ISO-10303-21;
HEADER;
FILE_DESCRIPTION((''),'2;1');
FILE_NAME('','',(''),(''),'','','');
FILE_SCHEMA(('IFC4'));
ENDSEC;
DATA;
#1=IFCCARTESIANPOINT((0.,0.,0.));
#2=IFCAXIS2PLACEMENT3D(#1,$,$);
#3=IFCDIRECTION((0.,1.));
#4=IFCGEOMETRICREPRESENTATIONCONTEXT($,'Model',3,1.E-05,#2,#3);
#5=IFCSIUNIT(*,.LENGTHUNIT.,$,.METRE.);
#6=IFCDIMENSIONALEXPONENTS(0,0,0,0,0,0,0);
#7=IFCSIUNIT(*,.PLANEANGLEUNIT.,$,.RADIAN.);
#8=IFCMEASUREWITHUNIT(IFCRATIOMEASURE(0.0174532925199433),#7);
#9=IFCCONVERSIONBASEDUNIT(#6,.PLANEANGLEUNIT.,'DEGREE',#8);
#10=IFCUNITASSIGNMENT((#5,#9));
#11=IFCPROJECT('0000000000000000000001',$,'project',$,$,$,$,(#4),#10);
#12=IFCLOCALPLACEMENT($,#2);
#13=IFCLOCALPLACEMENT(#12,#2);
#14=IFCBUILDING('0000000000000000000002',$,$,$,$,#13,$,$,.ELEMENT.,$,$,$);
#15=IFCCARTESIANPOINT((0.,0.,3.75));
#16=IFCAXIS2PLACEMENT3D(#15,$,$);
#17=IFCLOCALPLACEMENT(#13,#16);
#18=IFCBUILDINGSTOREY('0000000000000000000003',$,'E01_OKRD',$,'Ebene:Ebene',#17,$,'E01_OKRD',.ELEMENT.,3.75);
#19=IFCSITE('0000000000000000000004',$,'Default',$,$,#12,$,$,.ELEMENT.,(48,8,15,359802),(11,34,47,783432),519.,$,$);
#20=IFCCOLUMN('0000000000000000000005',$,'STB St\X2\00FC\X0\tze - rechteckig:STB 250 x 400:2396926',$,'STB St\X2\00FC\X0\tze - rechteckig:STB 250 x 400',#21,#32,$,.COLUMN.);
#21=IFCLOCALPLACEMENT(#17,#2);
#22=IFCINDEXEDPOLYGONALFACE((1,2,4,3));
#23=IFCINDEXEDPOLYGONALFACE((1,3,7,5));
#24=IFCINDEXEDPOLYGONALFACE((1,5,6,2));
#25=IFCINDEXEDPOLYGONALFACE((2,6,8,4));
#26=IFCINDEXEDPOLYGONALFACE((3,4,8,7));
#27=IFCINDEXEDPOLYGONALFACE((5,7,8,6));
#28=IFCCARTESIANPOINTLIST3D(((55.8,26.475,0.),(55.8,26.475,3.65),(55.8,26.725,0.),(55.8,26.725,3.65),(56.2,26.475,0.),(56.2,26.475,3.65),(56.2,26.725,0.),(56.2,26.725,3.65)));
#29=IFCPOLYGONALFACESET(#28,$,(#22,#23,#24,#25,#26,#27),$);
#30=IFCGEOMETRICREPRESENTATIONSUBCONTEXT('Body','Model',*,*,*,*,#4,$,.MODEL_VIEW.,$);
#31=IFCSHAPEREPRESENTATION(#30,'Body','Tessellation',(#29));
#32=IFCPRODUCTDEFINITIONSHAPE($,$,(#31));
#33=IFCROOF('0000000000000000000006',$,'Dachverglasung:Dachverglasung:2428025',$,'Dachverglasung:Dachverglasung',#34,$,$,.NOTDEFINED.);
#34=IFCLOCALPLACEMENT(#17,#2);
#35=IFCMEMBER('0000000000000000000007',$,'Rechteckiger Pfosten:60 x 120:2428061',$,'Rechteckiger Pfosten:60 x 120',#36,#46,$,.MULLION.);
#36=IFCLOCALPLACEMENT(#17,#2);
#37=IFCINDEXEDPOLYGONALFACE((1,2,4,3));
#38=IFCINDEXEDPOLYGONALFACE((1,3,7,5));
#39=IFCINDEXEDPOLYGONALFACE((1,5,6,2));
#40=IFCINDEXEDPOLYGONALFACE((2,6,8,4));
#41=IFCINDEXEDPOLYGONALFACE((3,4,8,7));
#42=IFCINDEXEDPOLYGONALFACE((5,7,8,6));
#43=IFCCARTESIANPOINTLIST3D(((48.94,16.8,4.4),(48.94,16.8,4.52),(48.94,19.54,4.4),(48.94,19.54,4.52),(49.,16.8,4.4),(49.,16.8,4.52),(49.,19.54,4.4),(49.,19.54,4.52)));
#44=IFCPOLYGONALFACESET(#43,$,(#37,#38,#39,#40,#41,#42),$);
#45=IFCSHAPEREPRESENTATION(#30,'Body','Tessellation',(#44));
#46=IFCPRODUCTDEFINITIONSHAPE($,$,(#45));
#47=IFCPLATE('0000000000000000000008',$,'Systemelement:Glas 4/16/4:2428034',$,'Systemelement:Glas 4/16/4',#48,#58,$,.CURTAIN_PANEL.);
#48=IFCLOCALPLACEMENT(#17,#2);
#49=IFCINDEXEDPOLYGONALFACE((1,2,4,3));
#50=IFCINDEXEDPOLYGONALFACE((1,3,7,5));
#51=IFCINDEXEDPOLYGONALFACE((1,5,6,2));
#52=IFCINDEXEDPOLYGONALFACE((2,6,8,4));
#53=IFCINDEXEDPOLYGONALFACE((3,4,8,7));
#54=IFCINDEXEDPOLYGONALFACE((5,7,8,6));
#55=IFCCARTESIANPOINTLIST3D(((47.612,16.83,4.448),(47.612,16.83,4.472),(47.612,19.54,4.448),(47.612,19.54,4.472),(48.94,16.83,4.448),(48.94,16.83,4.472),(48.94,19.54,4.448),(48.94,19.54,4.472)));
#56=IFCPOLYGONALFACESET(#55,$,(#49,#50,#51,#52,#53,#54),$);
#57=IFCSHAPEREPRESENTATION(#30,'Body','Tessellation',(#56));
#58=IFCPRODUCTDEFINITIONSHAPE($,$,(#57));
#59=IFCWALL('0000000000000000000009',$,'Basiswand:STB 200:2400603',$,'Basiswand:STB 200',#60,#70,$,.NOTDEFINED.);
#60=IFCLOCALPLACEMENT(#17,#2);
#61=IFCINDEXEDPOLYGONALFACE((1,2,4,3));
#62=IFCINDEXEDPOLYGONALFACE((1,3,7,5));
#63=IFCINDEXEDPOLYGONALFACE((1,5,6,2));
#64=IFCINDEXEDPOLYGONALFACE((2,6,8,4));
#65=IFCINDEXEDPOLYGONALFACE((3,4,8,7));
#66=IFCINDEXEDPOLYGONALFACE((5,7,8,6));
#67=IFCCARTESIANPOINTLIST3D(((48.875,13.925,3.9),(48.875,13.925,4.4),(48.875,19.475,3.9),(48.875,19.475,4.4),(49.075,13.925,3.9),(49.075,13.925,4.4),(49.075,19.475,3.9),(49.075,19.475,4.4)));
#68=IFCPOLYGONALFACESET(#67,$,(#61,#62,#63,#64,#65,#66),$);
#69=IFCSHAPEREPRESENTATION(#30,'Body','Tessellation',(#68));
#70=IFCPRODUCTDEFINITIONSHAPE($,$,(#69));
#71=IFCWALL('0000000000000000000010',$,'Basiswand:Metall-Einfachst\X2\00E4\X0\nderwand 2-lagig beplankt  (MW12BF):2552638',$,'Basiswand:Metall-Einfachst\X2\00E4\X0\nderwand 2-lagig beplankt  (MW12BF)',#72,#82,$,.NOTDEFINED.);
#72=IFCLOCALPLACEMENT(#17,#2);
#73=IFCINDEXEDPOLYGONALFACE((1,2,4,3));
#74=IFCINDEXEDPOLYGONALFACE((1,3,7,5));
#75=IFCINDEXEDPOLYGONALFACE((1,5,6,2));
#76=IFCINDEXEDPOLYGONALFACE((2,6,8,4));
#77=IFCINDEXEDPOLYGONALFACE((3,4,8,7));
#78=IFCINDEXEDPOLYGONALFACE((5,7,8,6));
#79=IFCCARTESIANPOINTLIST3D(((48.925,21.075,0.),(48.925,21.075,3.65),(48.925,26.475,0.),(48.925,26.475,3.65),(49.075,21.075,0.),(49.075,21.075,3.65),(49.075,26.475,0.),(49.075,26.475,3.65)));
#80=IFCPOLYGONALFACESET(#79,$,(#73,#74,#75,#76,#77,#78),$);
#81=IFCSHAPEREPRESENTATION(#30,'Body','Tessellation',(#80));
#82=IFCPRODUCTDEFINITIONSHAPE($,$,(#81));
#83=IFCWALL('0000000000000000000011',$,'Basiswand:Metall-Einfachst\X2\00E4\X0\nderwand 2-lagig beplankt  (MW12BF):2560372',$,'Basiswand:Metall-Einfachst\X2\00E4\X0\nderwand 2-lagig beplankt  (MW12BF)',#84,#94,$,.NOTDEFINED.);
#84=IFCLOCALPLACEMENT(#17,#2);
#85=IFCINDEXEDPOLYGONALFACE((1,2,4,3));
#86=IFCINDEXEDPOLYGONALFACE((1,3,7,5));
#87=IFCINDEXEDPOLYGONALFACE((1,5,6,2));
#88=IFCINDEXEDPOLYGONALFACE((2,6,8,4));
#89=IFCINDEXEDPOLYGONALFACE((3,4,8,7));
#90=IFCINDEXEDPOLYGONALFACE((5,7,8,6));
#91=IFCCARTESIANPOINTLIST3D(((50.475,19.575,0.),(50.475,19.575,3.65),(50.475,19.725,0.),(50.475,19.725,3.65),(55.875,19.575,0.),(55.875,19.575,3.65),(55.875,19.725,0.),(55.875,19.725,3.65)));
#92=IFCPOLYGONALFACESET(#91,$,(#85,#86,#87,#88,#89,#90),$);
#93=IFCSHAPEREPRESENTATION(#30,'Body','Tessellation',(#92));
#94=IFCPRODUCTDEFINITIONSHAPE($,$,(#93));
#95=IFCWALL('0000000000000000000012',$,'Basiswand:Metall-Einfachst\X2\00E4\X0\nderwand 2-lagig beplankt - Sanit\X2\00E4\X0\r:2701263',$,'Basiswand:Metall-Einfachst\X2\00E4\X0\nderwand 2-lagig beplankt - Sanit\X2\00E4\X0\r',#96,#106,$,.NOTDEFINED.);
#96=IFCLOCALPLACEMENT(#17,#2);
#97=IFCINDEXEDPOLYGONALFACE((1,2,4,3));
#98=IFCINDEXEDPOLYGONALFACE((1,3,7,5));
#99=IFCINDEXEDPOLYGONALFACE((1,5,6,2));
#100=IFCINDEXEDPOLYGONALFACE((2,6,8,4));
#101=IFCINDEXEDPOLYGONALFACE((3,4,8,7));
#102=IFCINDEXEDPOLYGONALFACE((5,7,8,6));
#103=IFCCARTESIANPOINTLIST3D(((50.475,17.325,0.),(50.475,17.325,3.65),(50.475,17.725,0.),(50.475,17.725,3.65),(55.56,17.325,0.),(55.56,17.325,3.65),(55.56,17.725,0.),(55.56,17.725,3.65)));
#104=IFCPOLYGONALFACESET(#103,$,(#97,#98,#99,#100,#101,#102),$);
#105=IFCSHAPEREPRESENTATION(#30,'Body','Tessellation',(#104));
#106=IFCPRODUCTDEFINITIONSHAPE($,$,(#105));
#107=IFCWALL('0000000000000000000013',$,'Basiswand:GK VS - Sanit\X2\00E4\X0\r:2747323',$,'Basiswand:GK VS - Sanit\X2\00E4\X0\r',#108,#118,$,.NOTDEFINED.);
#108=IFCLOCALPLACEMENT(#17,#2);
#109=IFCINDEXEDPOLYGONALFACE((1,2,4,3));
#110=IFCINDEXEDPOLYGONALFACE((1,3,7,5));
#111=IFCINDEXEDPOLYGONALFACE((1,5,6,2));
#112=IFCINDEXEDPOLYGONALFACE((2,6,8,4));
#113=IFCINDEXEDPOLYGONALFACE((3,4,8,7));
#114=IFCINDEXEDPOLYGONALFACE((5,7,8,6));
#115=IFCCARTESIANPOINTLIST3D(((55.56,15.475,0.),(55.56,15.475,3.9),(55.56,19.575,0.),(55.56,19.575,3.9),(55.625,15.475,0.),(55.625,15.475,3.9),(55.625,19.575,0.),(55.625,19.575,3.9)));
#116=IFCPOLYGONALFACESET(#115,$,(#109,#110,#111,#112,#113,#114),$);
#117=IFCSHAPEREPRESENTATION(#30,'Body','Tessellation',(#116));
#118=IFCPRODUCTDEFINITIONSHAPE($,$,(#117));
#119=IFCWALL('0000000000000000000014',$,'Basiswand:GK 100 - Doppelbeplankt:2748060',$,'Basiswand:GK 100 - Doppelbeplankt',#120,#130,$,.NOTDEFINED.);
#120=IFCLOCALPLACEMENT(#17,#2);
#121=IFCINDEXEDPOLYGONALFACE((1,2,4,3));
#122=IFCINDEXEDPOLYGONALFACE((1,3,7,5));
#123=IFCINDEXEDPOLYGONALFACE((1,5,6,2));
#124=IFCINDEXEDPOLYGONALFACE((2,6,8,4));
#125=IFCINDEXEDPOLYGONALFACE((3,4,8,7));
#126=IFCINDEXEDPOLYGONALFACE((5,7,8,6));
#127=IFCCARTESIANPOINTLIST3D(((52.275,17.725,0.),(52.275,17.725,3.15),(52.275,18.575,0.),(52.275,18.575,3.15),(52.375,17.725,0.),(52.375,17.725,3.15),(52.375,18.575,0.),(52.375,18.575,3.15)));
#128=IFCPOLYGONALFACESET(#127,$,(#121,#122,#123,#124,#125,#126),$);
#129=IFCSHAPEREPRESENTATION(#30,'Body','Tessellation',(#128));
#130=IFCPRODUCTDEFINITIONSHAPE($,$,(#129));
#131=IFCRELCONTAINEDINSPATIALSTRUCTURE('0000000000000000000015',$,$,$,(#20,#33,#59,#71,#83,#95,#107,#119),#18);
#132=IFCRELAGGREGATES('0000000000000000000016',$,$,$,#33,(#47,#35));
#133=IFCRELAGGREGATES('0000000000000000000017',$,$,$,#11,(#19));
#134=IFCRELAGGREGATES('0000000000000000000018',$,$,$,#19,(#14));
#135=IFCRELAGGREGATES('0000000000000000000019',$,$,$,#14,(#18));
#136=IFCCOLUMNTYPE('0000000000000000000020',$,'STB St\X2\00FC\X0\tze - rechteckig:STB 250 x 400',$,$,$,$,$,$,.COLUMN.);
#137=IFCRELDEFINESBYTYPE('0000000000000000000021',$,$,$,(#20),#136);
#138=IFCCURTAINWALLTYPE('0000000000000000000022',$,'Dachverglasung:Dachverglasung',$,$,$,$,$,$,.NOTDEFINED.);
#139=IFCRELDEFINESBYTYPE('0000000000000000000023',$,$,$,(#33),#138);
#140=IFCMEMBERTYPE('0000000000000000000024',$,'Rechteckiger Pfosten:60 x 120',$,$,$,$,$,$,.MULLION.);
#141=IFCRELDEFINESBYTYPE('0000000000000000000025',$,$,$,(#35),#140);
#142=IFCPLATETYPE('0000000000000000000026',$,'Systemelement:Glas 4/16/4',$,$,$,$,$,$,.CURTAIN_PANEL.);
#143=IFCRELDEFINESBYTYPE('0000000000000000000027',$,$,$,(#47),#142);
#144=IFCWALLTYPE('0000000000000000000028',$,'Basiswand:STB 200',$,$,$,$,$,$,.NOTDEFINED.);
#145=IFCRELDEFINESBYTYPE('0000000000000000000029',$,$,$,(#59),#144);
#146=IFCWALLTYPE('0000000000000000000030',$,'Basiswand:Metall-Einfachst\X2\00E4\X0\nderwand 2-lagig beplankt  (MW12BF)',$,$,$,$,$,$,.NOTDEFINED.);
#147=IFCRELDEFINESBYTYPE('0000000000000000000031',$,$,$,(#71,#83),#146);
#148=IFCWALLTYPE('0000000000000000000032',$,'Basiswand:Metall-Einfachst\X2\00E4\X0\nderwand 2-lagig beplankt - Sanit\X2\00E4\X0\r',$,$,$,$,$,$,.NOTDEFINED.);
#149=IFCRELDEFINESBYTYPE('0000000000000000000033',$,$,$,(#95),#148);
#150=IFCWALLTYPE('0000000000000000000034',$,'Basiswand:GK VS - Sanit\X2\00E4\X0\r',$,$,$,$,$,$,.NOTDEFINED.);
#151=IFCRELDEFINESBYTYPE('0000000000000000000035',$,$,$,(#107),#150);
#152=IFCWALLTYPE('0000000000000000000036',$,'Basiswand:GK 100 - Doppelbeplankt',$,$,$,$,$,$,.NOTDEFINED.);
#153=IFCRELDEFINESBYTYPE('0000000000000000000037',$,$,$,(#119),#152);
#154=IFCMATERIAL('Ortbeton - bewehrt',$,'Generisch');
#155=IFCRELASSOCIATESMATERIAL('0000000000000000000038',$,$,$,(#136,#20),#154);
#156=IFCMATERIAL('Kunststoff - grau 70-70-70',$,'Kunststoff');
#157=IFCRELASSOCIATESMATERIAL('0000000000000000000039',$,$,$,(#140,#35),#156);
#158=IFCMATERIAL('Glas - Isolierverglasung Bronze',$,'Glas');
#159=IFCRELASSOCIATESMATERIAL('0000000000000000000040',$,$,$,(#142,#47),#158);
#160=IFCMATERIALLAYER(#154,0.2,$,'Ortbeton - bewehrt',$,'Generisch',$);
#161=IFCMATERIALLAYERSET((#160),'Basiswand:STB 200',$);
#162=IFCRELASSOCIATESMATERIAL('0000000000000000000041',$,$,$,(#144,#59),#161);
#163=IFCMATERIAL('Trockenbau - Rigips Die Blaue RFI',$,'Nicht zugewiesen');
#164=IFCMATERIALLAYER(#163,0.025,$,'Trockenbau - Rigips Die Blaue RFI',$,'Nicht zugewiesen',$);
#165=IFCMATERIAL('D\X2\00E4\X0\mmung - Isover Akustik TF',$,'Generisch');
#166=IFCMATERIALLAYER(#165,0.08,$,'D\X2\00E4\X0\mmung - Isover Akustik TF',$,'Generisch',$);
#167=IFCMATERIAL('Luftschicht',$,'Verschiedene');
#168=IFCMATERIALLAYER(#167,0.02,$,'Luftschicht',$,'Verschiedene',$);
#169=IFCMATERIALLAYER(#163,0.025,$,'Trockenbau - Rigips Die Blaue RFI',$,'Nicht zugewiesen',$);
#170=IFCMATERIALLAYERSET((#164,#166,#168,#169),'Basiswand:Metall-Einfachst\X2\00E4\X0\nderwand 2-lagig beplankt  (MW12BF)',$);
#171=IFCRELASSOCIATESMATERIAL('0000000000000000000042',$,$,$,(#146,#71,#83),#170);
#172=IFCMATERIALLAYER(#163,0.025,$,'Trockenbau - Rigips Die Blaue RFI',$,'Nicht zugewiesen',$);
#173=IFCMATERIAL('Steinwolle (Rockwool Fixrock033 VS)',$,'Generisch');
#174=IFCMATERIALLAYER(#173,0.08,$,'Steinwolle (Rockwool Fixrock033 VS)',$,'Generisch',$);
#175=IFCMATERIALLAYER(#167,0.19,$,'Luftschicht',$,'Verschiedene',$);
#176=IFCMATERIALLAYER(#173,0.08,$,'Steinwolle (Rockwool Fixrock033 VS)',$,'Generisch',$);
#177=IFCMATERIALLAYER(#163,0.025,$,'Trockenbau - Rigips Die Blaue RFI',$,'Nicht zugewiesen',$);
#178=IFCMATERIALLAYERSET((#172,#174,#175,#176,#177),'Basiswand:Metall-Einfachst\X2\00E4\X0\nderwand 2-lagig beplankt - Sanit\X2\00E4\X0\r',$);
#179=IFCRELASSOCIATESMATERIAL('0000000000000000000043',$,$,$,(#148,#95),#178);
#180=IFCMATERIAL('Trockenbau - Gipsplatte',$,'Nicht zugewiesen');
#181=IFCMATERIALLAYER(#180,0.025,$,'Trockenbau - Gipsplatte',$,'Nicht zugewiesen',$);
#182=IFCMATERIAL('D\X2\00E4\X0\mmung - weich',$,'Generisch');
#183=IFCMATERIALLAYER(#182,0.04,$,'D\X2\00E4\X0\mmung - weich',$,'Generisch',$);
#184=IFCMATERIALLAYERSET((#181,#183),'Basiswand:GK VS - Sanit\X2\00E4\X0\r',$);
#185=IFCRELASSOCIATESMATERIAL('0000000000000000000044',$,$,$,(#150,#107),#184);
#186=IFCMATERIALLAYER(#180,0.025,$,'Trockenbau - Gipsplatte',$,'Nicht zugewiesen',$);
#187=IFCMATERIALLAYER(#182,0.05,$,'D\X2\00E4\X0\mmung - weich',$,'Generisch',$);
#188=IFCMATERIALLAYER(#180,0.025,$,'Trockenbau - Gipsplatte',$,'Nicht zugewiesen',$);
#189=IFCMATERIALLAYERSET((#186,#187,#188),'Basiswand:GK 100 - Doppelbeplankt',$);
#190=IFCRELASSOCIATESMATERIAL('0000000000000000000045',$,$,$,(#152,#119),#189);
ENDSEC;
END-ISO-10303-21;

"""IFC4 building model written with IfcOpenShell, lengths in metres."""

from ifc_helpers import new_model, entity, si_unit, converted_unit, direction, frame, frame_2d, origin, origin_2d_with_axis, place, context, subcontext, project, spatial, rectangle, extrude, shape, source, transform, mapped, material, layer, layer_set, layer_usage, material_profile, profile_set, profile_usage, type_object, type_shapes, element, aggregate, save


model = new_model("IFC4")

# Units and contexts
model_context = context("Model", 3, precision=1e-05, world=origin(), true_north=direction((0.0, 1.0)))
body_context = subcontext(model_context, "Body", "Model", "MODEL_VIEW")
footprint_context = subcontext(model_context, "FootPrint", "Model", "MODEL_VIEW")
ifc_project = project(units=[si_unit("LENGTHUNIT", "METRE"), converted_unit("PLANEANGLEUNIT", "DEGREE", entity("IfcRatioMeasure", 0.0174532925199433), si_unit("PLANEANGLEUNIT", "RADIAN"), dimensions=[0, 0, 0, 0, 0, 0, 0])], contexts=[model_context])

# Site, building, storey
site_placement = place(None, frame((0.0, 0.0, 0.0)))
site = spatial("IfcSite", under=ifc_project, at=site_placement, Name="Default", CompositionType="ELEMENT", RefLatitude=(48, 8, 15, 359802), RefLongitude=(11, 34, 47, 783432), RefElevation=519.0)
building_placement = place(site_placement, origin())
building = spatial("IfcBuilding", under=site, at=building_placement, CompositionType="ELEMENT")
storey_placement = place(building_placement, frame((0.0, 0.0, 3.75)))
storey = spatial("IfcBuildingStorey", under=building, at=storey_placement, Name="E01_OKRD", ObjectType="Ebene:Ebene", LongName="E01_OKRD", CompositionType="ELEMENT", Elevation=3.75)

# Column
ifc_material_1 = material(Name="Ortbeton - bewehrt", Category="Generisch")
ifc_material_profile_1 = material_profile(ifc_material_1, rectangle(XDim=0.4, YDim=0.25, at=frame_2d((0.0, 0.0), x_axis=(1.0, 0.0))), Name="STB 250 x 400")
ifc_profile_set_1 = profile_set([ifc_material_profile_1], Name="STB 250 x 400")
ifc_profile_usage_1 = profile_usage(ifc_profile_set_1)
column_type = type_object("IfcColumnType", Name="STB Stütze - rechteckig:STB 250 x 400", PredefinedType="COLUMN", material=ifc_profile_set_1)
shared_shape_1 = source(origin(), body_context, "Body", "SweptSolid", [
    extrude(rectangle(XDim=0.4, YDim=0.25, at=frame_2d((0.0, 0.0), x_axis=(1.0, 0.0))), frame((0.2, 0.125, 0.0), z_axis=(0.0, 0.0, 1.0), x_axis=(-1.0, 0.0, 0.0)), (0.0, 0.0, 1.0), 3.65),
])
type_shapes(column_type, [shared_shape_1])
column_placement = place(storey_placement, frame((55.8, 26.475, 0.0)))
element("IfcColumn", 1, at=column_placement, inside=storey, type_object=column_type, material=ifc_profile_usage_1, Name="STB Stütze - rechteckig:STB 250 x 400:2396926", ObjectType="STB Stütze - rechteckig:STB 250 x 400", PredefinedType="COLUMN", context=body_context, shape_type="MappedRepresentation", body=[
    mapped(shared_shape_1, transform((0.0, 0.0, 0.0), scale=1.0)),
])

# Roof, member, plate
curtain_wall_type = type_object("IfcCurtainWallType", Name="Dachverglasung:Dachverglasung", PredefinedType="NOTDEFINED")
roof_placement = place(storey_placement, frame((0.0, 0.0, -3.75)))
roof = element("IfcRoof", 2, at=roof_placement, inside=storey, type_object=curtain_wall_type, Name="Dachverglasung:Dachverglasung:2428025", ObjectType="Dachverglasung:Dachverglasung", PredefinedType="NOTDEFINED")
ifc_material_2 = material(Name="Kunststoff - grau 70-70-70", Category="Kunststoff")
ifc_material_profile_2 = material_profile(ifc_material_2, rectangle(XDim=0.06, YDim=0.12, at=frame_2d((0.0, 0.0), x_axis=(1.0, 0.0))), Name="60 x 120")
ifc_profile_set_2 = profile_set([ifc_material_profile_2], Name="60 x 120")
ifc_profile_usage_2 = profile_usage(ifc_profile_set_2)
member_type = type_object("IfcMemberType", Name="Rechteckiger Pfosten:60 x 120", PredefinedType="MULLION", material=ifc_profile_set_2)
shared_shape_2 = source(origin(), body_context, "Body", "SweptSolid", [
    extrude(rectangle(XDim=0.06, YDim=0.12, at=origin_2d_with_axis()), frame((-0.03, 0.0, -2.74), z_axis=(0.0, 0.0, 1.0), x_axis=(-1.0, 0.0, 0.0)), (0.0, 0.0, 1.0), 2.74),
])
type_shapes(member_type, [shared_shape_2])
member_placement = place(storey_placement, frame((49.0, 19.54, 4.46), z_axis=(0.0, 1.0, 0.0), x_axis=(1.0, 0.0, 0.0)))
member = element("IfcMember", 3, at=member_placement, type_object=member_type, material=ifc_profile_usage_2, Name="Rechteckiger Pfosten:60 x 120:2428061", ObjectType="Rechteckiger Pfosten:60 x 120", PredefinedType="MULLION", context=body_context, shape_type="MappedRepresentation", body=[
    mapped(shared_shape_2, transform((0.0, 0.0, 0.0), scale=1.0)),
])
ifc_material_3 = material(Name="Glas - Isolierverglasung Bronze", Category="Glas")
plate_type = type_object("IfcPlateType", Name="Systemelement:Glas 4/16/4", PredefinedType="CURTAIN_PANEL", material=ifc_material_3)
shared_shape_3 = source(origin(), body_context, "Body", "SweptSolid", [
    extrude(rectangle(XDim=0.024, YDim=2.71, at=origin_2d_with_axis()), frame((0.0, 0.0, 0.0), z_axis=(0.0, 0.0, 1.0), x_axis=(0.0, 1.0, 0.0)), (0.0, 0.0, 1.0), 1.328),
])
cartesian_point = entity("IfcCartesianPoint", [1.355, -0.012])
shared_shape_4 = source(origin(), footprint_context, "FootPrint", "Curve2D", [
    entity("IfcPolyline", [cartesian_point, entity("IfcCartesianPoint", [1.355, 0.012]), entity("IfcCartesianPoint", [-1.355, 0.012]), entity("IfcCartesianPoint", [-1.355, -0.012]), cartesian_point]),
])
type_shapes(plate_type, [shared_shape_3, shared_shape_4])
plate_placement = place(roof_placement, frame((48.94, 18.185, 8.21), z_axis=(-1.0, 0.0, 0.0), x_axis=(0.0, 1.0, 0.0)))
plate = element("IfcPlate", 4, at=plate_placement, type_object=plate_type, material=ifc_material_3, Name="Systemelement:Glas 4/16/4:2428034", ObjectType="Systemelement:Glas 4/16/4", PredefinedType="CURTAIN_PANEL", shapes=[
    shape(body_context, "Body", "MappedRepresentation", [mapped(shared_shape_3, transform((0.0, 0.0, 0.0), scale=1.0))]),
    shape(body_context, "Body", "MappedRepresentation", [mapped(shared_shape_4, transform((0.0, 0.0, 0.0), scale=1.0))]),
])
aggregate(roof, [plate, member])

# Walls
ifc_layer_1 = layer(ifc_material_1, 0.2, Name="Ortbeton - bewehrt", Category="Generisch")
ifc_layer_set_1 = layer_set([ifc_layer_1], Name="Basiswand:STB 200")
ifc_layer_usage_1 = layer_usage(ifc_layer_set_1, "AXIS2", "NEGATIVE", 0.1)
wall_type_1 = type_object("IfcWallType", Name="Basiswand:STB 200", PredefinedType="NOTDEFINED", material=ifc_layer_set_1)
wall_1_placement = place(storey_placement, frame((48.975, 19.475, 3.9), z_axis=(0.0, 0.0, 1.0), x_axis=(0.0, -1.0, 0.0)))
element("IfcWall", 5, at=wall_1_placement, inside=storey, type_object=wall_type_1, material=ifc_layer_usage_1, Name="Basiswand:STB 200:2400603", ObjectType="Basiswand:STB 200", PredefinedType="NOTDEFINED", context=body_context, shape_type="SweptSolid", body=[
    extrude(rectangle(XDim=5.55, YDim=0.2, at=frame_2d((2.775, 0.0), x_axis=(-1.0, 0.0))), origin(), (0.0, 0.0, 1.0), 0.5),
])
ifc_material_4 = material(Name="Trockenbau - Rigips Die Blaue RFI", Category="Nicht zugewiesen")
ifc_layer_2 = layer(ifc_material_4, 0.025, Name="Trockenbau - Rigips Die Blaue RFI", Category="Nicht zugewiesen")
ifc_material_5 = material(Name="Dämmung - Isover Akustik TF", Category="Generisch")
ifc_layer_3 = layer(ifc_material_5, 0.08, Name="Dämmung - Isover Akustik TF", Category="Generisch")
ifc_material_6 = material(Name="Luftschicht", Category="Verschiedene")
ifc_layer_4 = layer(ifc_material_6, 0.02, Name="Luftschicht", Category="Verschiedene")
ifc_layer_5 = layer(ifc_material_4, 0.025, Name="Trockenbau - Rigips Die Blaue RFI", Category="Nicht zugewiesen")
ifc_layer_set_2 = layer_set([ifc_layer_2, ifc_layer_3, ifc_layer_4, ifc_layer_5], Name="Basiswand:Metall-Einfachständerwand 2-lagig beplankt  (MW12BF)")
ifc_layer_usage_2 = layer_usage(ifc_layer_set_2, "AXIS2", "NEGATIVE", 0.075)
wall_type_2 = type_object("IfcWallType", Name="Basiswand:Metall-Einfachständerwand 2-lagig beplankt  (MW12BF)", PredefinedType="NOTDEFINED", material=ifc_layer_set_2)
wall_2_placement = place(storey_placement, frame((49.0, 21.075, 0.0), z_axis=(0.0, 0.0, 1.0), x_axis=(0.0, 1.0, 0.0)))
element("IfcWall", 6, at=wall_2_placement, inside=storey, type_object=wall_type_2, material=ifc_layer_usage_2, Name="Basiswand:Metall-Einfachständerwand 2-lagig beplankt  (MW12BF):2552638", ObjectType="Basiswand:Metall-Einfachständerwand 2-lagig beplankt  (MW12BF)", PredefinedType="NOTDEFINED", context=body_context, shape_type="SweptSolid", body=[
    extrude(rectangle(XDim=5.4, YDim=0.15, at=frame_2d((2.7, 0.0), x_axis=(-1.0, 0.0))), origin(), (0.0, 0.0, 1.0), 3.65),
])
ifc_layer_usage_3 = layer_usage(ifc_layer_set_2, "AXIS2", "POSITIVE", -0.075)
wall_3_placement = place(storey_placement, frame((55.875, 19.65, 0.0), z_axis=(0.0, 0.0, 1.0), x_axis=(-1.0, 0.0, 0.0)))
element("IfcWall", 7, at=wall_3_placement, inside=storey, type_object=wall_type_2, material=ifc_layer_usage_3, Name="Basiswand:Metall-Einfachständerwand 2-lagig beplankt  (MW12BF):2560372", ObjectType="Basiswand:Metall-Einfachständerwand 2-lagig beplankt  (MW12BF)", PredefinedType="NOTDEFINED", context=body_context, shape_type="SweptSolid", body=[
    extrude(rectangle(XDim=5.4, YDim=0.15, at=frame_2d((2.7, 0.0), x_axis=(-1.0, 0.0))), origin(), (0.0, 0.0, 1.0), 3.65),
])
ifc_layer_6 = layer(ifc_material_4, 0.025, Name="Trockenbau - Rigips Die Blaue RFI", Category="Nicht zugewiesen")
ifc_material_7 = material(Name="Steinwolle (Rockwool Fixrock033 VS)", Category="Generisch")
ifc_layer_7 = layer(ifc_material_7, 0.08, Name="Steinwolle (Rockwool Fixrock033 VS)", Category="Generisch")
ifc_layer_8 = layer(ifc_material_6, 0.19, Name="Luftschicht", Category="Verschiedene")
ifc_layer_9 = layer(ifc_material_7, 0.08, Name="Steinwolle (Rockwool Fixrock033 VS)", Category="Generisch")
ifc_layer_10 = layer(ifc_material_4, 0.025, Name="Trockenbau - Rigips Die Blaue RFI", Category="Nicht zugewiesen")
ifc_layer_set_3 = layer_set([ifc_layer_6, ifc_layer_7, ifc_layer_8, ifc_layer_9, ifc_layer_10], Name="Basiswand:Metall-Einfachständerwand 2-lagig beplankt - Sanitär")
ifc_layer_usage_4 = layer_usage(ifc_layer_set_3, "AXIS2", "NEGATIVE", 0.2)
wall_type_3 = type_object("IfcWallType", Name="Basiswand:Metall-Einfachständerwand 2-lagig beplankt - Sanitär", PredefinedType="NOTDEFINED", material=ifc_layer_set_3)
wall_4_placement = place(storey_placement, frame((55.56, 17.525, 0.0), z_axis=(0.0, 0.0, 1.0), x_axis=(-1.0, 0.0, 0.0)))
element("IfcWall", 8, at=wall_4_placement, inside=storey, type_object=wall_type_3, material=ifc_layer_usage_4, Name="Basiswand:Metall-Einfachständerwand 2-lagig beplankt - Sanitär:2701263", ObjectType="Basiswand:Metall-Einfachständerwand 2-lagig beplankt - Sanitär", PredefinedType="NOTDEFINED", context=body_context, shape_type="SweptSolid", body=[
    extrude(rectangle(XDim=5.085, YDim=0.4, at=frame_2d((2.5425, 0.0), x_axis=(-1.0, 0.0))), origin(), (0.0, 0.0, 1.0), 3.65),
])
ifc_material_8 = material(Name="Trockenbau - Gipsplatte", Category="Nicht zugewiesen")
ifc_layer_11 = layer(ifc_material_8, 0.025, Name="Trockenbau - Gipsplatte", Category="Nicht zugewiesen")
ifc_material_9 = material(Name="Dämmung - weich", Category="Generisch")
ifc_layer_12 = layer(ifc_material_9, 0.04, Name="Dämmung - weich", Category="Generisch")
ifc_layer_set_4 = layer_set([ifc_layer_11, ifc_layer_12], Name="Basiswand:GK VS - Sanitär")
ifc_layer_usage_5 = layer_usage(ifc_layer_set_4, "AXIS2", "POSITIVE", -0.0325)
wall_type_4 = type_object("IfcWallType", Name="Basiswand:GK VS - Sanitär", PredefinedType="NOTDEFINED", material=ifc_layer_set_4)
wall_5_placement = place(storey_placement, frame((55.5925, 19.575, 0.0), z_axis=(0.0, 0.0, 1.0), x_axis=(0.0, -1.0, 0.0)))
element("IfcWall", 9, at=wall_5_placement, inside=storey, type_object=wall_type_4, material=ifc_layer_usage_5, Name="Basiswand:GK VS - Sanitär:2747323", ObjectType="Basiswand:GK VS - Sanitär", PredefinedType="NOTDEFINED", context=body_context, shape_type="SweptSolid", body=[
    extrude(rectangle(XDim=4.1, YDim=0.065, at=frame_2d((2.05, 0.0), x_axis=(-1.0, 0.0))), origin(), (0.0, 0.0, 1.0), 3.9),
])
ifc_layer_13 = layer(ifc_material_8, 0.025, Name="Trockenbau - Gipsplatte", Category="Nicht zugewiesen")
ifc_layer_14 = layer(ifc_material_9, 0.05, Name="Dämmung - weich", Category="Generisch")
ifc_layer_15 = layer(ifc_material_8, 0.025, Name="Trockenbau - Gipsplatte", Category="Nicht zugewiesen")
ifc_layer_set_5 = layer_set([ifc_layer_13, ifc_layer_14, ifc_layer_15], Name="Basiswand:GK 100 - Doppelbeplankt")
ifc_layer_usage_6 = layer_usage(ifc_layer_set_5, "AXIS2", "NEGATIVE", 0.05)
wall_type_5 = type_object("IfcWallType", Name="Basiswand:GK 100 - Doppelbeplankt", PredefinedType="NOTDEFINED", material=ifc_layer_set_5)
wall_6_placement = place(storey_placement, frame((52.325, 17.725, 0.0), z_axis=(0.0, 0.0, 1.0), x_axis=(0.0, 1.0, 0.0)))
element("IfcWall", 10, at=wall_6_placement, inside=storey, type_object=wall_type_5, material=ifc_layer_usage_6, Name="Basiswand:GK 100 - Doppelbeplankt:2748060", ObjectType="Basiswand:GK 100 - Doppelbeplankt", PredefinedType="NOTDEFINED", context=body_context, shape_type="SweptSolid", body=[
    extrude(rectangle(XDim=0.85, YDim=0.1, at=frame_2d((0.425, 0.0), x_axis=(-1.0, 0.0))), origin(), (0.0, 0.0, 1.0), 3.15),
])

save(model, "model.ifc")
